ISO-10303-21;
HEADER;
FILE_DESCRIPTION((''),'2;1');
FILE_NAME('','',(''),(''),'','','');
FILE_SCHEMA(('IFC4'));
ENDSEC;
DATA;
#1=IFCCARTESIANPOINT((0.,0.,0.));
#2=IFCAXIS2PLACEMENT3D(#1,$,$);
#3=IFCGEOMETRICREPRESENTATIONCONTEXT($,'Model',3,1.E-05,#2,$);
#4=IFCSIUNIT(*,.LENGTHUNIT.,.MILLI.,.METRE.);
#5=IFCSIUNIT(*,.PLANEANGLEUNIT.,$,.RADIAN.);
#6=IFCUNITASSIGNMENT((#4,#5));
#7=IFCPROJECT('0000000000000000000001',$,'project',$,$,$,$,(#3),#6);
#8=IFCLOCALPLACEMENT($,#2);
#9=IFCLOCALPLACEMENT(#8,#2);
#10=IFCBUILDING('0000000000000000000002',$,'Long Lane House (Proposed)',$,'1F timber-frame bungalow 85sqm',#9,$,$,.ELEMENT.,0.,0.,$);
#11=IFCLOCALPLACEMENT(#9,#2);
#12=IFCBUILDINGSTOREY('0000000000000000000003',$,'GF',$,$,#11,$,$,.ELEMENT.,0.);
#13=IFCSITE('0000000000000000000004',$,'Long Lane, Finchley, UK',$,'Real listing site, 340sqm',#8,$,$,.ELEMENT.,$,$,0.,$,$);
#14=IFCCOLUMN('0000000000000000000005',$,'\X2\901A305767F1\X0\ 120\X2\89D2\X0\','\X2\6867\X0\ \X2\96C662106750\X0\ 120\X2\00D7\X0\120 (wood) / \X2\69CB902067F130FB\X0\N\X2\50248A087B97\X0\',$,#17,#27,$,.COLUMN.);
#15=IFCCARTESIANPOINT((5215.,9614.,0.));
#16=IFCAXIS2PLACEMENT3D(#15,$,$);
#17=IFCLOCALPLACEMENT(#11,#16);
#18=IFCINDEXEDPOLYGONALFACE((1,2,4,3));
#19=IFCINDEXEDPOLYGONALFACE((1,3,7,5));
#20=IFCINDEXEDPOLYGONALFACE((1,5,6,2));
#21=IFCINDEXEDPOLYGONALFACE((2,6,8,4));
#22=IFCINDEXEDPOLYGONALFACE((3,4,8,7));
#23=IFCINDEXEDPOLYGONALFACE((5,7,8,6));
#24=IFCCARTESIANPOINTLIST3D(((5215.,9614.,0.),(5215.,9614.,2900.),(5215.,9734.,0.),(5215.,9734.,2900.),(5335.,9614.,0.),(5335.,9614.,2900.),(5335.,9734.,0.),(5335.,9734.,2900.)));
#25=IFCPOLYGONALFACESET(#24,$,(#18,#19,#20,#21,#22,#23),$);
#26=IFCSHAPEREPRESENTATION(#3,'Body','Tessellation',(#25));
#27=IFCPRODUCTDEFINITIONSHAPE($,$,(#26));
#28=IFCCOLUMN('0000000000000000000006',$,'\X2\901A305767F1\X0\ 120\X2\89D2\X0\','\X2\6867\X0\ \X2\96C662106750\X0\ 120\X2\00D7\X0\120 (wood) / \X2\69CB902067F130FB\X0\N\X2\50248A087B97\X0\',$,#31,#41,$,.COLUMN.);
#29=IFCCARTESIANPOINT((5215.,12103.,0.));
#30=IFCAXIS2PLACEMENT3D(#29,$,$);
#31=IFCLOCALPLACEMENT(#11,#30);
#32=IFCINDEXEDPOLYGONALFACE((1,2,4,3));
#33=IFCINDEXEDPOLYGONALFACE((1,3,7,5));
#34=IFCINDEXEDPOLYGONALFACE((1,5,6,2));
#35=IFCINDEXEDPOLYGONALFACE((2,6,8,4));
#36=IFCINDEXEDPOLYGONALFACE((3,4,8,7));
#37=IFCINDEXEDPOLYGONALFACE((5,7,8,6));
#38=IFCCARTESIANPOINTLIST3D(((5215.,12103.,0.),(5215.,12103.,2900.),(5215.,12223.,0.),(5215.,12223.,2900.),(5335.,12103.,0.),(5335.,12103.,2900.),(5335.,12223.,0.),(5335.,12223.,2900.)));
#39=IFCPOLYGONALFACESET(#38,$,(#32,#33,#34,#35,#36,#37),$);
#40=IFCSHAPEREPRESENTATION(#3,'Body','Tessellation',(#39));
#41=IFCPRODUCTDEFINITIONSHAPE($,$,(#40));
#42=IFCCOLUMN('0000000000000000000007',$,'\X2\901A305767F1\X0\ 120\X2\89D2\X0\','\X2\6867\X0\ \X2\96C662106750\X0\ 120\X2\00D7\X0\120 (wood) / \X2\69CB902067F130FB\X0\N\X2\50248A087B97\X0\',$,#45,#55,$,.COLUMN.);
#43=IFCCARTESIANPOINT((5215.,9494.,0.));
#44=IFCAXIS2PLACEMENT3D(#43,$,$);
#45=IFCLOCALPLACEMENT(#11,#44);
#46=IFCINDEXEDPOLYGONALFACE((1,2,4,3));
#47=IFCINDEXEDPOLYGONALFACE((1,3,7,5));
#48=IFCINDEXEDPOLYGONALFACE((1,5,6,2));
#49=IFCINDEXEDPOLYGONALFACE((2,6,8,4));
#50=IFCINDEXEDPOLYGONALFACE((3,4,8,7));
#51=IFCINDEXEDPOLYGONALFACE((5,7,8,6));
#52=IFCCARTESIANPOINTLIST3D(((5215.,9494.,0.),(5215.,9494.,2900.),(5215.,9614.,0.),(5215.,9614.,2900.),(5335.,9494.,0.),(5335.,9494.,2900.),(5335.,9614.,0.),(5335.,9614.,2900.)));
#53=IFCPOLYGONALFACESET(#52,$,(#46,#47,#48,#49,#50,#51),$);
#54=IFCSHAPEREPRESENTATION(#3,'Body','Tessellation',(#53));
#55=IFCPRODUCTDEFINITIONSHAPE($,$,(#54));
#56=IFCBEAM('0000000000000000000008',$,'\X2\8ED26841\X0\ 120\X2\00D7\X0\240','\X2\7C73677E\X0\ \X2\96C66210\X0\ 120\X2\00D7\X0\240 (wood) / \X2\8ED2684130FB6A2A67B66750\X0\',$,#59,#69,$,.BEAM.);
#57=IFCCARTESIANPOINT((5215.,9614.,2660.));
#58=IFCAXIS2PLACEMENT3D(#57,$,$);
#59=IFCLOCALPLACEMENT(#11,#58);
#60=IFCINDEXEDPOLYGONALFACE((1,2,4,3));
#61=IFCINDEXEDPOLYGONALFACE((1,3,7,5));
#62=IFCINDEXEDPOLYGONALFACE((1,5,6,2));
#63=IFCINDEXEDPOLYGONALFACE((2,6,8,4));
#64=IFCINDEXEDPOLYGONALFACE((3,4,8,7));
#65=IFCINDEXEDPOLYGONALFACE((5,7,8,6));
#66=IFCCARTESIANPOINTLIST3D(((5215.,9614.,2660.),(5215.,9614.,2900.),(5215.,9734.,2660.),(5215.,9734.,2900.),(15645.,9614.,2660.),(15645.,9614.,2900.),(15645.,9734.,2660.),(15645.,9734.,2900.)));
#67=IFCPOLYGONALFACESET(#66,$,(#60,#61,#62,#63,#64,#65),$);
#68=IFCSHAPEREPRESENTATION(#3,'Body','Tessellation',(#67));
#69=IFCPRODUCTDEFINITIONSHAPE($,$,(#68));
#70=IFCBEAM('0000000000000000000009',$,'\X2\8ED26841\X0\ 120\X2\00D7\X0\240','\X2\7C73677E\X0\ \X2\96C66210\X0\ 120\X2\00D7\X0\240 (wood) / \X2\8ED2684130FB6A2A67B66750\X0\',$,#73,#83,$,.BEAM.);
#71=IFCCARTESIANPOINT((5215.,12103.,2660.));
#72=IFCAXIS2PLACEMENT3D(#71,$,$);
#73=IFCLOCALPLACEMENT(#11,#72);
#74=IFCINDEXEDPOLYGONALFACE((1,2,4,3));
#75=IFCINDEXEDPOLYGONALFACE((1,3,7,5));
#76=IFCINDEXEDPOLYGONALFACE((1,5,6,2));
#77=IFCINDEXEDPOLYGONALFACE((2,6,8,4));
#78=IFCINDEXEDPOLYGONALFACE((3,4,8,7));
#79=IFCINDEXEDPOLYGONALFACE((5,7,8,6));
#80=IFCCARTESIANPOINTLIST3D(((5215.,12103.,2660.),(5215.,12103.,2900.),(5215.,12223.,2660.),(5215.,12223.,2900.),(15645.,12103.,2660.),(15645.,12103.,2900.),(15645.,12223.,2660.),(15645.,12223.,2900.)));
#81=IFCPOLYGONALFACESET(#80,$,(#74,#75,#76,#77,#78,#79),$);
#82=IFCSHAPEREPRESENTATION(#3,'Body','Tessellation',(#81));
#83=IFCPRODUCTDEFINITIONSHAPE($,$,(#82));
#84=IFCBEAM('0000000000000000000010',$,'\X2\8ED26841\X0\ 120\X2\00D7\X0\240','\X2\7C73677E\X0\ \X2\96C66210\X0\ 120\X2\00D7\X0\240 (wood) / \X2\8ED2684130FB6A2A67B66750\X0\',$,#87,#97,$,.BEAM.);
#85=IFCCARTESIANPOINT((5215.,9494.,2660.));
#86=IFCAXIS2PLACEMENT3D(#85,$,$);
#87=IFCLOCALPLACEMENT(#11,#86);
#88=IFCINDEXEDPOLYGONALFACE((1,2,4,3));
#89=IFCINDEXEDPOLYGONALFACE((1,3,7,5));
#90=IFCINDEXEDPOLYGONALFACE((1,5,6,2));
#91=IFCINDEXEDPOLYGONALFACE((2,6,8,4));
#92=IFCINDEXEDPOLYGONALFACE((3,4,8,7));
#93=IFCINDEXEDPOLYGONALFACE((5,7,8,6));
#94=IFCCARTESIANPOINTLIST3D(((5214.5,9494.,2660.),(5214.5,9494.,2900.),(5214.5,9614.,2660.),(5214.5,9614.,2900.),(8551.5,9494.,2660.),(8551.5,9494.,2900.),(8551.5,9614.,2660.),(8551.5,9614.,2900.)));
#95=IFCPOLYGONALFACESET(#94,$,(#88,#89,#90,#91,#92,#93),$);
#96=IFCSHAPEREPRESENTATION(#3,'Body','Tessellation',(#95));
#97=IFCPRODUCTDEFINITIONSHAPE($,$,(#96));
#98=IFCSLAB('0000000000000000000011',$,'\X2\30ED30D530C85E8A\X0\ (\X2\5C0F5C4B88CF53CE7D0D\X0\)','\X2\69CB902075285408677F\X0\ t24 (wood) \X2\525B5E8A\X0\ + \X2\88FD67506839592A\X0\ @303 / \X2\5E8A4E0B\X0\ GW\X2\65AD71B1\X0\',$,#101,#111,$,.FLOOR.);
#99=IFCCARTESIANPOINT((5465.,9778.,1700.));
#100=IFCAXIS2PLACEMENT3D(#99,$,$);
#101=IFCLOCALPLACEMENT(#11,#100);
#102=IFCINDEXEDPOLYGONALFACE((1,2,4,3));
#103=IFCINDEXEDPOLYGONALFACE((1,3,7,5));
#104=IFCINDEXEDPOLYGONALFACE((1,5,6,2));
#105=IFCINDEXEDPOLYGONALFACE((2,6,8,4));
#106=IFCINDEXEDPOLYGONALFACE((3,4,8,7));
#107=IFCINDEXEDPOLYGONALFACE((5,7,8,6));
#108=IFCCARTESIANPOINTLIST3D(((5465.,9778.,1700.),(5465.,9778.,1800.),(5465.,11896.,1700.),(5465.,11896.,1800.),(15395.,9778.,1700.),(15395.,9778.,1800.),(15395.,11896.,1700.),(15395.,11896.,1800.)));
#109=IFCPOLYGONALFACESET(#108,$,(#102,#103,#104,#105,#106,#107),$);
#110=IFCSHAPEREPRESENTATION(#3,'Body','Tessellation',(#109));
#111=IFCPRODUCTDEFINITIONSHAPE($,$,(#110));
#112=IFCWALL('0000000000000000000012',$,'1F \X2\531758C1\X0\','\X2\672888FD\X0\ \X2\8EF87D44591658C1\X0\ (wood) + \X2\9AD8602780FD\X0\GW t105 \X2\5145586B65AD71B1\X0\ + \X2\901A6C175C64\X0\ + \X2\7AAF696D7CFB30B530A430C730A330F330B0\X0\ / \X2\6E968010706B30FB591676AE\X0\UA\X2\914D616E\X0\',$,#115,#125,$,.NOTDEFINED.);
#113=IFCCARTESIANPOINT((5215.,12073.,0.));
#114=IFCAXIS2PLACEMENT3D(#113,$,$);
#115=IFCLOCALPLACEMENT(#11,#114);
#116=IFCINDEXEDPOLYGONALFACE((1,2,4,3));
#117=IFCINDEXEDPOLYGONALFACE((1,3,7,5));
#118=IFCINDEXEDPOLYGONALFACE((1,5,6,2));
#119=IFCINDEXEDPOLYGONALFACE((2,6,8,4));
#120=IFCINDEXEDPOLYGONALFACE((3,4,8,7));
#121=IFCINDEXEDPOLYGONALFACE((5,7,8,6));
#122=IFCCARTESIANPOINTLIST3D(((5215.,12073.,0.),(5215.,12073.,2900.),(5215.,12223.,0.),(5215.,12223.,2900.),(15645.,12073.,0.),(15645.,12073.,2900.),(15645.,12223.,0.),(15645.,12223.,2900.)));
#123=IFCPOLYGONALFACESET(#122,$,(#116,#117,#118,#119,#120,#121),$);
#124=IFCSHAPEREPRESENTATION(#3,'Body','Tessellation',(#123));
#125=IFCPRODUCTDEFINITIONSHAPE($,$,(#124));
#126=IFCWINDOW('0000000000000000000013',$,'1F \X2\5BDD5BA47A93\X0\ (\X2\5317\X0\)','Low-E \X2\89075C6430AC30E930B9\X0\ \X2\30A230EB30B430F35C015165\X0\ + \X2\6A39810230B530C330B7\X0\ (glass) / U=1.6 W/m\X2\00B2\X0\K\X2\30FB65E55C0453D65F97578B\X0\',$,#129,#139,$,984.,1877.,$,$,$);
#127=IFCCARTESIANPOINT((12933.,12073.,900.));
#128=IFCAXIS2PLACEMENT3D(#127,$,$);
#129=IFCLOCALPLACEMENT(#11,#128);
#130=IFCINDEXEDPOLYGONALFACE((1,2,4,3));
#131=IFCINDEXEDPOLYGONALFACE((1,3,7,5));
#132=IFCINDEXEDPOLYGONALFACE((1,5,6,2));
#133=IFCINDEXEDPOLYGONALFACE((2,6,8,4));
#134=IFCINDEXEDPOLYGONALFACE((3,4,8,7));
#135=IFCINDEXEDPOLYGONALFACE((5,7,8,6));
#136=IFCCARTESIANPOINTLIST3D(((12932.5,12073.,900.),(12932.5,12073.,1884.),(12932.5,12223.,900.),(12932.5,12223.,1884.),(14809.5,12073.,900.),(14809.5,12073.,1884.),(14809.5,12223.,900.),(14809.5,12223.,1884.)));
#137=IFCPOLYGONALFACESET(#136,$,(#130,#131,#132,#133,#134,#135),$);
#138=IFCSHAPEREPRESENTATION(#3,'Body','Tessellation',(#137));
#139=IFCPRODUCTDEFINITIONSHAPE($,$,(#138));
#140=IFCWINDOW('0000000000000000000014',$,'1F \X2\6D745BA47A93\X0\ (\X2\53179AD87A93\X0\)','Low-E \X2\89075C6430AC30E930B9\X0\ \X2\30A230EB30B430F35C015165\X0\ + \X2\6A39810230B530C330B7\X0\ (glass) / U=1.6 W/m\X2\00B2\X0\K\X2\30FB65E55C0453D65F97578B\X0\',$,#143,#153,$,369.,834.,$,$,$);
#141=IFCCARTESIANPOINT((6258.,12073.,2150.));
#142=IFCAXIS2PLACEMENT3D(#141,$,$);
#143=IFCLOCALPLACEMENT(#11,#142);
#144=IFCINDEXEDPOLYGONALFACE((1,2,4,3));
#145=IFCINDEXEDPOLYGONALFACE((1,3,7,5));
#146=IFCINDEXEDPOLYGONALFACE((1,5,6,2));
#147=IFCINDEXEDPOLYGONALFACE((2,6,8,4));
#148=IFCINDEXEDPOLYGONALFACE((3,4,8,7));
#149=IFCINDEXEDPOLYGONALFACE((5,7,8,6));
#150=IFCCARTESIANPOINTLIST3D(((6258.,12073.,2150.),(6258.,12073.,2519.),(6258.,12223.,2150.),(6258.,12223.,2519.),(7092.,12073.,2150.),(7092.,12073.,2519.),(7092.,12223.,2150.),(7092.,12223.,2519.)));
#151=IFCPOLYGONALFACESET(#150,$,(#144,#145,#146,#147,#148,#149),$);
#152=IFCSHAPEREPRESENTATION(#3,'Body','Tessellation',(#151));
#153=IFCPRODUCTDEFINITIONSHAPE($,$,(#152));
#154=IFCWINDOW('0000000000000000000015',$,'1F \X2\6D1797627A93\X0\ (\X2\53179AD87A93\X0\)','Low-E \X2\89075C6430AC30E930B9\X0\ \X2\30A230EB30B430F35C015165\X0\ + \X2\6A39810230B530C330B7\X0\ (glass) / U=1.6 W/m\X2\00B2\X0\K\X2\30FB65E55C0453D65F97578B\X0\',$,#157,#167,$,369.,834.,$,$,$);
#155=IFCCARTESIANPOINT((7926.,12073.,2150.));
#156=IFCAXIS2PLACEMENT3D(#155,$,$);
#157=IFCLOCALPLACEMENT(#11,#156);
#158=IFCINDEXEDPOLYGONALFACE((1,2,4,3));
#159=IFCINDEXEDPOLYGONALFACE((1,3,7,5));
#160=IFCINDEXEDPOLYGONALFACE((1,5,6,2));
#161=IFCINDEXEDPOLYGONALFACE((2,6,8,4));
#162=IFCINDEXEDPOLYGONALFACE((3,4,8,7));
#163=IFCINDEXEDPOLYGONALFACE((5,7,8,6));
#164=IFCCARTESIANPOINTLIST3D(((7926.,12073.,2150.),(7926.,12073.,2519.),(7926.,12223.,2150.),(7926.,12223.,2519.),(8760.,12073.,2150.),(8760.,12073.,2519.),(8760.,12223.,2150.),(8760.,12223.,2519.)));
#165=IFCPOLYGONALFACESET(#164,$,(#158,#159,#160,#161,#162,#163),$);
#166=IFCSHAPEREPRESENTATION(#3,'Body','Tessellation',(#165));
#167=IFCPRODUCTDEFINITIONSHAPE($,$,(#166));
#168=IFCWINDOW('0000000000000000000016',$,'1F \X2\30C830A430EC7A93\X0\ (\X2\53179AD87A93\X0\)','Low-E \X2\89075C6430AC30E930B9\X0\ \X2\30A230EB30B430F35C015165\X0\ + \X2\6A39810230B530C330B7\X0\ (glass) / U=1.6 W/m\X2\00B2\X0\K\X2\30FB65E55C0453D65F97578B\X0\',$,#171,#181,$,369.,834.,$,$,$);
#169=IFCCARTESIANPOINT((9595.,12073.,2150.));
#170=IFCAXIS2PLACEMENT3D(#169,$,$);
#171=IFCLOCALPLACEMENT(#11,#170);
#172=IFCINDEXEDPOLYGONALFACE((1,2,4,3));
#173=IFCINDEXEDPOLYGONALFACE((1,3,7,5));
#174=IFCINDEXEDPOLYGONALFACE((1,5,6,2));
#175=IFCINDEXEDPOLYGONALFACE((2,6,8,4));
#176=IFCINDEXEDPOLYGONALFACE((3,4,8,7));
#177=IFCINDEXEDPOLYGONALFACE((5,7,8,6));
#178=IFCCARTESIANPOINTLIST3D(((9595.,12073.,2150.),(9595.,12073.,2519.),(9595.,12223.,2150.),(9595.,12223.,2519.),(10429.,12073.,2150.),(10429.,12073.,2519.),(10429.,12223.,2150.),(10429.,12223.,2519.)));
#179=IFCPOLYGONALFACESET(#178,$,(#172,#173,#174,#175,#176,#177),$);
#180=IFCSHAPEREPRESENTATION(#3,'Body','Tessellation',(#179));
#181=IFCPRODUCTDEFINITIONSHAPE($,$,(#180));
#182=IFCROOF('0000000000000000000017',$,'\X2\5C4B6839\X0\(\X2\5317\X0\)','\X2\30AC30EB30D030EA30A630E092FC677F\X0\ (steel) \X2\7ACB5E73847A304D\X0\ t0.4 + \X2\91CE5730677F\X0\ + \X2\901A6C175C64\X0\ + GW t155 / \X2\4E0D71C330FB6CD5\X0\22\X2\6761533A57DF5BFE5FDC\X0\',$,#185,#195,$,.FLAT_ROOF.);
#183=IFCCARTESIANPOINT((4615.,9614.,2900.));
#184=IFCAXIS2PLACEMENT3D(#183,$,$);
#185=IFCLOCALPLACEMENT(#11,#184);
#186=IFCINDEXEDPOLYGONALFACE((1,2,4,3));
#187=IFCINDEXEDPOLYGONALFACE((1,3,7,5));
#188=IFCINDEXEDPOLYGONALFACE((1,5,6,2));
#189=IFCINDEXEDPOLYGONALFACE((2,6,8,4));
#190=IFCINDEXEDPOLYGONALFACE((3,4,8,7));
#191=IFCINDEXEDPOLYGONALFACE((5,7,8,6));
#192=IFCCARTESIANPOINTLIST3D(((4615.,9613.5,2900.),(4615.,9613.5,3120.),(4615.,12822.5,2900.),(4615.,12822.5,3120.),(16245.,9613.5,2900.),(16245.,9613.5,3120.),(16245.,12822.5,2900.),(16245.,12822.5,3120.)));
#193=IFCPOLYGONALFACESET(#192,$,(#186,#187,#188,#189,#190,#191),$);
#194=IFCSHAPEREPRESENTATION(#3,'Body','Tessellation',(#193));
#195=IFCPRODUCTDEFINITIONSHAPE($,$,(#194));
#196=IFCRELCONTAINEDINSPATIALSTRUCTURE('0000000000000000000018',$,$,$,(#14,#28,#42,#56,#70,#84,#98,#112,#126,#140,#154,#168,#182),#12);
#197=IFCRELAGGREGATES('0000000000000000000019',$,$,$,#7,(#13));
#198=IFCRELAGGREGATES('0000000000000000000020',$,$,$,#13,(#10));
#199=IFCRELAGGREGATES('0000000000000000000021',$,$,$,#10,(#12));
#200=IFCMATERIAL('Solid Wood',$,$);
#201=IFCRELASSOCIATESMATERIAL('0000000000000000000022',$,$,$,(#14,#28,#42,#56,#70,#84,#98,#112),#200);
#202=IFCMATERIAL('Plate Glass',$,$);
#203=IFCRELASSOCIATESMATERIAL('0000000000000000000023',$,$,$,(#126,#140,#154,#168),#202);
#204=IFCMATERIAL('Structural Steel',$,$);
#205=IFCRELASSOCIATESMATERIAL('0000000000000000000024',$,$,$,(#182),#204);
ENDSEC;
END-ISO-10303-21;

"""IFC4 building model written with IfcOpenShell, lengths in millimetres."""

from ifc_helpers import new_model, si_unit, frame, frame_2d, origin, place, context, project, spatial, rectangle, extrude, material, element, fill, save


model = new_model("IFC4")

# Units and contexts
model_context = context("Model", 3, precision=1e-05, world=origin())
ifc_project = project(units=[si_unit("LENGTHUNIT", "METRE", prefix="MILLI"), si_unit("PLANEANGLEUNIT", "RADIAN")], contexts=[model_context])

# Site, building, storey
site_placement = place(None, origin())
site = spatial("IfcSite", under=ifc_project, at=site_placement, Name="Long Lane, Finchley, UK", ObjectType="Real listing site, 340sqm", CompositionType="ELEMENT", RefElevation=0.0)
building_placement = place(site_placement, origin())
building = spatial("IfcBuilding", under=site, at=building_placement, Name="Long Lane House (Proposed)", ObjectType="1F timber-frame bungalow 85sqm", CompositionType="ELEMENT", ElevationOfRefHeight=0.0, ElevationOfTerrain=0.0)
storey_placement = place(building_placement, origin())
storey = spatial("IfcBuildingStorey", under=building, at=storey_placement, Name="GF", CompositionType="ELEMENT", Elevation=0.0)

# Columns
ifc_material_1 = material(Name="Solid Wood")
column_1_placement = place(storey_placement, frame((5215.0, 9614.0, 0.0)))
element("IfcColumn", 1, at=column_1_placement, inside=storey, material=ifc_material_1, Name="通し柱 120角", Description="桧 集成材 120×120 (wood) / 構造柱・N値計算", PredefinedType="COLUMN", context=model_context, shape_type="SweptSolid", body=[
    extrude(rectangle(XDim=120.0, YDim=120.0, at=frame_2d((60.0, 60.0))), frame((5215.0, 9614.0, 0.0)), (0.0, 0.0, 1.0), 2900.0),
])
column_2_placement = place(storey_placement, frame((5215.0, 12103.0, 0.0)))
element("IfcColumn", 2, at=column_2_placement, inside=storey, material=ifc_material_1, Name="通し柱 120角", Description="桧 集成材 120×120 (wood) / 構造柱・N値計算", PredefinedType="COLUMN", context=model_context, shape_type="SweptSolid", body=[
    extrude(rectangle(XDim=120.0, YDim=120.0, at=frame_2d((60.0, 60.0))), frame((5215.0, 12103.0, 0.0)), (0.0, 0.0, 1.0), 2900.0),
])
column_3_placement = place(storey_placement, frame((5215.0, 9494.0, 0.0)))
element("IfcColumn", 3, at=column_3_placement, inside=storey, material=ifc_material_1, Name="通し柱 120角", Description="桧 集成材 120×120 (wood) / 構造柱・N値計算", PredefinedType="COLUMN", context=model_context, shape_type="SweptSolid", body=[
    extrude(rectangle(XDim=120.0, YDim=120.0, at=frame_2d((60.0, 60.0))), frame((5215.0, 9494.0, 0.0)), (0.0, 0.0, 1.0), 2900.0),
])

# Beams
beam_1_placement = place(storey_placement, frame((5215.0, 9614.0, 2660.0)))
element("IfcBeam", 4, at=beam_1_placement, inside=storey, material=ifc_material_1, Name="軒桁 120×240", Description="米松 集成 120×240 (wood) / 軒桁・横架材", PredefinedType="BEAM", context=model_context, shape_type="SweptSolid", body=[
    extrude(rectangle(XDim=10430.0, YDim=120.0, at=frame_2d((5215.0, 60.0))), frame((5215.0, 9614.0, 2660.0)), (0.0, 0.0, 1.0), 240.0),
])
beam_2_placement = place(storey_placement, frame((5215.0, 12103.0, 2660.0)))
element("IfcBeam", 5, at=beam_2_placement, inside=storey, material=ifc_material_1, Name="軒桁 120×240", Description="米松 集成 120×240 (wood) / 軒桁・横架材", PredefinedType="BEAM", context=model_context, shape_type="SweptSolid", body=[
    extrude(rectangle(XDim=10430.0, YDim=120.0, at=frame_2d((5215.0, 60.0))), frame((5215.0, 12103.0, 2660.0)), (0.0, 0.0, 1.0), 240.0),
])
beam_3_placement = place(storey_placement, frame((5215.0, 9494.0, 2660.0)))
element("IfcBeam", 6, at=beam_3_placement, inside=storey, material=ifc_material_1, Name="軒桁 120×240", Description="米松 集成 120×240 (wood) / 軒桁・横架材", PredefinedType="BEAM", context=model_context, shape_type="SweptSolid", body=[
    extrude(rectangle(XDim=3337.0, YDim=120.0, at=frame_2d((1668.0, 60.0))), frame((5215.0, 9494.0, 2660.0)), (0.0, 0.0, 1.0), 240.0),
])

# Slab
slab_1_placement = place(storey_placement, frame((5465.0, 9778.0, 1700.0)))
element("IfcSlab", 7, at=slab_1_placement, inside=storey, material=ifc_material_1, Name="ロフト床 (小屋裏収納)", Description="構造用合板 t24 (wood) 剛床 + 製材根太 @303 / 床下 GW断熱", PredefinedType="FLOOR", context=model_context, shape_type="SweptSolid", body=[
    extrude(rectangle(XDim=9930.0, YDim=2118.0, at=frame_2d((4965.0, 1059.0))), frame((5465.0, 9778.0, 1700.0)), (0.0, 0.0, 1.0), 100.0),
])

# Wall, openings, windows
wall_1_placement = place(storey_placement, frame((5215.0, 12073.0, 0.0)))
wall_1 = element("IfcWall", 8, at=wall_1_placement, inside=storey, material=ifc_material_1, Name="1F 北壁", Description="木製 軸組外壁 (wood) + 高性能GW t105 充填断熱 + 通気層 + 窯業系サイディング / 準耐火・外皮UA配慮", PredefinedType="NOTDEFINED", context=model_context, shape_type="SweptSolid", body=[
    extrude(rectangle(XDim=10430.0, YDim=150.0, at=frame_2d((5215.0, 75.0))), frame((5215.0, 12073.0, 0.0)), (0.0, 0.0, 1.0), 2900.0),
])
opening_1_placement = place(storey_placement, frame((12933.0, 12073.0, 900.0)))
opening_1 = element("IfcOpeningElement", 9, at=opening_1_placement, cuts=wall_1, PredefinedType="NOTDEFINED", context=model_context, shape_type="SweptSolid", body=[
    extrude(rectangle(XDim=1877.0, YDim=150.0, at=frame_2d((938.0, 75.0))), frame((12933.0, 12073.0, 900.0)), (0.0, 0.0, 1.0), 984.0),
])
opening_2_placement = place(storey_placement, frame((6258.0, 12073.0, 2150.0)))
opening_2 = element("IfcOpeningElement", 10, at=opening_2_placement, cuts=wall_1, PredefinedType="NOTDEFINED", context=model_context, shape_type="SweptSolid", body=[
    extrude(rectangle(XDim=834.0, YDim=150.0, at=frame_2d((417.0, 75.0))), frame((6258.0, 12073.0, 2150.0)), (0.0, 0.0, 1.0), 369.0),
])
opening_3_placement = place(storey_placement, frame((7926.0, 12073.0, 2150.0)))
opening_3 = element("IfcOpeningElement", 11, at=opening_3_placement, cuts=wall_1, PredefinedType="NOTDEFINED", context=model_context, shape_type="SweptSolid", body=[
    extrude(rectangle(XDim=834.0, YDim=150.0, at=frame_2d((417.0, 75.0))), frame((7926.0, 12073.0, 2150.0)), (0.0, 0.0, 1.0), 369.0),
])
opening_4_placement = place(storey_placement, frame((9595.0, 12073.0, 2150.0)))
opening_4 = element("IfcOpeningElement", 12, at=opening_4_placement, cuts=wall_1, PredefinedType="NOTDEFINED", context=model_context, shape_type="SweptSolid", body=[
    extrude(rectangle(XDim=834.0, YDim=150.0, at=frame_2d((417.0, 75.0))), frame((9595.0, 12073.0, 2150.0)), (0.0, 0.0, 1.0), 369.0),
])
ifc_material_2 = material(Name="Plate Glass")
window_1_placement = place(storey_placement, frame((12933.0, 12073.0, 900.0)))
window_1 = element("IfcWindow", 13, at=window_1_placement, inside=storey, material=ifc_material_2, Name="1F 寝室窓 (北)", Description="Low-E 複層ガラス アルゴン封入 + 樹脂サッシ (glass) / U=1.6 W/m²K・日射取得型", OverallHeight=984.0, OverallWidth=1877.0, context=model_context, shape_type="SweptSolid", body=[
    extrude(rectangle(XDim=1877.0, YDim=150.0, at=frame_2d((938.0, 75.0))), frame((12933.0, 12073.0, 900.0)), (0.0, 0.0, 1.0), 984.0),
])
fill(opening_1, window_1)
window_2_placement = place(storey_placement, frame((6258.0, 12073.0, 2150.0)))
window_2 = element("IfcWindow", 14, at=window_2_placement, inside=storey, material=ifc_material_2, Name="1F 浴室窓 (北高窓)", Description="Low-E 複層ガラス アルゴン封入 + 樹脂サッシ (glass) / U=1.6 W/m²K・日射取得型", OverallHeight=369.0, OverallWidth=834.0, context=model_context, shape_type="SweptSolid", body=[
    extrude(rectangle(XDim=834.0, YDim=150.0, at=frame_2d((417.0, 75.0))), frame((6258.0, 12073.0, 2150.0)), (0.0, 0.0, 1.0), 369.0),
])
fill(opening_2, window_2)
window_3_placement = place(storey_placement, frame((7926.0, 12073.0, 2150.0)))
window_3 = element("IfcWindow", 15, at=window_3_placement, inside=storey, material=ifc_material_2, Name="1F 洗面窓 (北高窓)", Description="Low-E 複層ガラス アルゴン封入 + 樹脂サッシ (glass) / U=1.6 W/m²K・日射取得型", OverallHeight=369.0, OverallWidth=834.0, context=model_context, shape_type="SweptSolid", body=[
    extrude(rectangle(XDim=834.0, YDim=150.0, at=frame_2d((417.0, 75.0))), frame((7926.0, 12073.0, 2150.0)), (0.0, 0.0, 1.0), 369.0),
])
fill(opening_3, window_3)
window_4_placement = place(storey_placement, frame((9595.0, 12073.0, 2150.0)))
window_4 = element("IfcWindow", 16, at=window_4_placement, inside=storey, material=ifc_material_2, Name="1F トイレ窓 (北高窓)", Description="Low-E 複層ガラス アルゴン封入 + 樹脂サッシ (glass) / U=1.6 W/m²K・日射取得型", OverallHeight=369.0, OverallWidth=834.0, context=model_context, shape_type="SweptSolid", body=[
    extrude(rectangle(XDim=834.0, YDim=150.0, at=frame_2d((417.0, 75.0))), frame((9595.0, 12073.0, 2150.0)), (0.0, 0.0, 1.0), 369.0),
])
fill(opening_4, window_4)

# Roof
ifc_material_3 = material(Name="Structural Steel")
roof_placement = place(storey_placement, frame((4615.0, 9614.0, 2900.0)))
element("IfcRoof", 17, at=roof_placement, inside=storey, material=ifc_material_3, Name="屋根(北)", Description="ガルバリウム鋼板 (steel) 立平葺き t0.4 + 野地板 + 通気層 + GW t155 / 不燃・法22条区域対応", PredefinedType="FLAT_ROOF", context=model_context, shape_type="SweptSolid", body=[
    extrude(rectangle(XDim=11630.0, YDim=3209.0, at=frame_2d((5815.0, 1604.0))), frame((4615.0, 9614.0, 2900.0)), (0.0, 0.0, 1.0), 220.0),
])

save(model, "model.ifc")
